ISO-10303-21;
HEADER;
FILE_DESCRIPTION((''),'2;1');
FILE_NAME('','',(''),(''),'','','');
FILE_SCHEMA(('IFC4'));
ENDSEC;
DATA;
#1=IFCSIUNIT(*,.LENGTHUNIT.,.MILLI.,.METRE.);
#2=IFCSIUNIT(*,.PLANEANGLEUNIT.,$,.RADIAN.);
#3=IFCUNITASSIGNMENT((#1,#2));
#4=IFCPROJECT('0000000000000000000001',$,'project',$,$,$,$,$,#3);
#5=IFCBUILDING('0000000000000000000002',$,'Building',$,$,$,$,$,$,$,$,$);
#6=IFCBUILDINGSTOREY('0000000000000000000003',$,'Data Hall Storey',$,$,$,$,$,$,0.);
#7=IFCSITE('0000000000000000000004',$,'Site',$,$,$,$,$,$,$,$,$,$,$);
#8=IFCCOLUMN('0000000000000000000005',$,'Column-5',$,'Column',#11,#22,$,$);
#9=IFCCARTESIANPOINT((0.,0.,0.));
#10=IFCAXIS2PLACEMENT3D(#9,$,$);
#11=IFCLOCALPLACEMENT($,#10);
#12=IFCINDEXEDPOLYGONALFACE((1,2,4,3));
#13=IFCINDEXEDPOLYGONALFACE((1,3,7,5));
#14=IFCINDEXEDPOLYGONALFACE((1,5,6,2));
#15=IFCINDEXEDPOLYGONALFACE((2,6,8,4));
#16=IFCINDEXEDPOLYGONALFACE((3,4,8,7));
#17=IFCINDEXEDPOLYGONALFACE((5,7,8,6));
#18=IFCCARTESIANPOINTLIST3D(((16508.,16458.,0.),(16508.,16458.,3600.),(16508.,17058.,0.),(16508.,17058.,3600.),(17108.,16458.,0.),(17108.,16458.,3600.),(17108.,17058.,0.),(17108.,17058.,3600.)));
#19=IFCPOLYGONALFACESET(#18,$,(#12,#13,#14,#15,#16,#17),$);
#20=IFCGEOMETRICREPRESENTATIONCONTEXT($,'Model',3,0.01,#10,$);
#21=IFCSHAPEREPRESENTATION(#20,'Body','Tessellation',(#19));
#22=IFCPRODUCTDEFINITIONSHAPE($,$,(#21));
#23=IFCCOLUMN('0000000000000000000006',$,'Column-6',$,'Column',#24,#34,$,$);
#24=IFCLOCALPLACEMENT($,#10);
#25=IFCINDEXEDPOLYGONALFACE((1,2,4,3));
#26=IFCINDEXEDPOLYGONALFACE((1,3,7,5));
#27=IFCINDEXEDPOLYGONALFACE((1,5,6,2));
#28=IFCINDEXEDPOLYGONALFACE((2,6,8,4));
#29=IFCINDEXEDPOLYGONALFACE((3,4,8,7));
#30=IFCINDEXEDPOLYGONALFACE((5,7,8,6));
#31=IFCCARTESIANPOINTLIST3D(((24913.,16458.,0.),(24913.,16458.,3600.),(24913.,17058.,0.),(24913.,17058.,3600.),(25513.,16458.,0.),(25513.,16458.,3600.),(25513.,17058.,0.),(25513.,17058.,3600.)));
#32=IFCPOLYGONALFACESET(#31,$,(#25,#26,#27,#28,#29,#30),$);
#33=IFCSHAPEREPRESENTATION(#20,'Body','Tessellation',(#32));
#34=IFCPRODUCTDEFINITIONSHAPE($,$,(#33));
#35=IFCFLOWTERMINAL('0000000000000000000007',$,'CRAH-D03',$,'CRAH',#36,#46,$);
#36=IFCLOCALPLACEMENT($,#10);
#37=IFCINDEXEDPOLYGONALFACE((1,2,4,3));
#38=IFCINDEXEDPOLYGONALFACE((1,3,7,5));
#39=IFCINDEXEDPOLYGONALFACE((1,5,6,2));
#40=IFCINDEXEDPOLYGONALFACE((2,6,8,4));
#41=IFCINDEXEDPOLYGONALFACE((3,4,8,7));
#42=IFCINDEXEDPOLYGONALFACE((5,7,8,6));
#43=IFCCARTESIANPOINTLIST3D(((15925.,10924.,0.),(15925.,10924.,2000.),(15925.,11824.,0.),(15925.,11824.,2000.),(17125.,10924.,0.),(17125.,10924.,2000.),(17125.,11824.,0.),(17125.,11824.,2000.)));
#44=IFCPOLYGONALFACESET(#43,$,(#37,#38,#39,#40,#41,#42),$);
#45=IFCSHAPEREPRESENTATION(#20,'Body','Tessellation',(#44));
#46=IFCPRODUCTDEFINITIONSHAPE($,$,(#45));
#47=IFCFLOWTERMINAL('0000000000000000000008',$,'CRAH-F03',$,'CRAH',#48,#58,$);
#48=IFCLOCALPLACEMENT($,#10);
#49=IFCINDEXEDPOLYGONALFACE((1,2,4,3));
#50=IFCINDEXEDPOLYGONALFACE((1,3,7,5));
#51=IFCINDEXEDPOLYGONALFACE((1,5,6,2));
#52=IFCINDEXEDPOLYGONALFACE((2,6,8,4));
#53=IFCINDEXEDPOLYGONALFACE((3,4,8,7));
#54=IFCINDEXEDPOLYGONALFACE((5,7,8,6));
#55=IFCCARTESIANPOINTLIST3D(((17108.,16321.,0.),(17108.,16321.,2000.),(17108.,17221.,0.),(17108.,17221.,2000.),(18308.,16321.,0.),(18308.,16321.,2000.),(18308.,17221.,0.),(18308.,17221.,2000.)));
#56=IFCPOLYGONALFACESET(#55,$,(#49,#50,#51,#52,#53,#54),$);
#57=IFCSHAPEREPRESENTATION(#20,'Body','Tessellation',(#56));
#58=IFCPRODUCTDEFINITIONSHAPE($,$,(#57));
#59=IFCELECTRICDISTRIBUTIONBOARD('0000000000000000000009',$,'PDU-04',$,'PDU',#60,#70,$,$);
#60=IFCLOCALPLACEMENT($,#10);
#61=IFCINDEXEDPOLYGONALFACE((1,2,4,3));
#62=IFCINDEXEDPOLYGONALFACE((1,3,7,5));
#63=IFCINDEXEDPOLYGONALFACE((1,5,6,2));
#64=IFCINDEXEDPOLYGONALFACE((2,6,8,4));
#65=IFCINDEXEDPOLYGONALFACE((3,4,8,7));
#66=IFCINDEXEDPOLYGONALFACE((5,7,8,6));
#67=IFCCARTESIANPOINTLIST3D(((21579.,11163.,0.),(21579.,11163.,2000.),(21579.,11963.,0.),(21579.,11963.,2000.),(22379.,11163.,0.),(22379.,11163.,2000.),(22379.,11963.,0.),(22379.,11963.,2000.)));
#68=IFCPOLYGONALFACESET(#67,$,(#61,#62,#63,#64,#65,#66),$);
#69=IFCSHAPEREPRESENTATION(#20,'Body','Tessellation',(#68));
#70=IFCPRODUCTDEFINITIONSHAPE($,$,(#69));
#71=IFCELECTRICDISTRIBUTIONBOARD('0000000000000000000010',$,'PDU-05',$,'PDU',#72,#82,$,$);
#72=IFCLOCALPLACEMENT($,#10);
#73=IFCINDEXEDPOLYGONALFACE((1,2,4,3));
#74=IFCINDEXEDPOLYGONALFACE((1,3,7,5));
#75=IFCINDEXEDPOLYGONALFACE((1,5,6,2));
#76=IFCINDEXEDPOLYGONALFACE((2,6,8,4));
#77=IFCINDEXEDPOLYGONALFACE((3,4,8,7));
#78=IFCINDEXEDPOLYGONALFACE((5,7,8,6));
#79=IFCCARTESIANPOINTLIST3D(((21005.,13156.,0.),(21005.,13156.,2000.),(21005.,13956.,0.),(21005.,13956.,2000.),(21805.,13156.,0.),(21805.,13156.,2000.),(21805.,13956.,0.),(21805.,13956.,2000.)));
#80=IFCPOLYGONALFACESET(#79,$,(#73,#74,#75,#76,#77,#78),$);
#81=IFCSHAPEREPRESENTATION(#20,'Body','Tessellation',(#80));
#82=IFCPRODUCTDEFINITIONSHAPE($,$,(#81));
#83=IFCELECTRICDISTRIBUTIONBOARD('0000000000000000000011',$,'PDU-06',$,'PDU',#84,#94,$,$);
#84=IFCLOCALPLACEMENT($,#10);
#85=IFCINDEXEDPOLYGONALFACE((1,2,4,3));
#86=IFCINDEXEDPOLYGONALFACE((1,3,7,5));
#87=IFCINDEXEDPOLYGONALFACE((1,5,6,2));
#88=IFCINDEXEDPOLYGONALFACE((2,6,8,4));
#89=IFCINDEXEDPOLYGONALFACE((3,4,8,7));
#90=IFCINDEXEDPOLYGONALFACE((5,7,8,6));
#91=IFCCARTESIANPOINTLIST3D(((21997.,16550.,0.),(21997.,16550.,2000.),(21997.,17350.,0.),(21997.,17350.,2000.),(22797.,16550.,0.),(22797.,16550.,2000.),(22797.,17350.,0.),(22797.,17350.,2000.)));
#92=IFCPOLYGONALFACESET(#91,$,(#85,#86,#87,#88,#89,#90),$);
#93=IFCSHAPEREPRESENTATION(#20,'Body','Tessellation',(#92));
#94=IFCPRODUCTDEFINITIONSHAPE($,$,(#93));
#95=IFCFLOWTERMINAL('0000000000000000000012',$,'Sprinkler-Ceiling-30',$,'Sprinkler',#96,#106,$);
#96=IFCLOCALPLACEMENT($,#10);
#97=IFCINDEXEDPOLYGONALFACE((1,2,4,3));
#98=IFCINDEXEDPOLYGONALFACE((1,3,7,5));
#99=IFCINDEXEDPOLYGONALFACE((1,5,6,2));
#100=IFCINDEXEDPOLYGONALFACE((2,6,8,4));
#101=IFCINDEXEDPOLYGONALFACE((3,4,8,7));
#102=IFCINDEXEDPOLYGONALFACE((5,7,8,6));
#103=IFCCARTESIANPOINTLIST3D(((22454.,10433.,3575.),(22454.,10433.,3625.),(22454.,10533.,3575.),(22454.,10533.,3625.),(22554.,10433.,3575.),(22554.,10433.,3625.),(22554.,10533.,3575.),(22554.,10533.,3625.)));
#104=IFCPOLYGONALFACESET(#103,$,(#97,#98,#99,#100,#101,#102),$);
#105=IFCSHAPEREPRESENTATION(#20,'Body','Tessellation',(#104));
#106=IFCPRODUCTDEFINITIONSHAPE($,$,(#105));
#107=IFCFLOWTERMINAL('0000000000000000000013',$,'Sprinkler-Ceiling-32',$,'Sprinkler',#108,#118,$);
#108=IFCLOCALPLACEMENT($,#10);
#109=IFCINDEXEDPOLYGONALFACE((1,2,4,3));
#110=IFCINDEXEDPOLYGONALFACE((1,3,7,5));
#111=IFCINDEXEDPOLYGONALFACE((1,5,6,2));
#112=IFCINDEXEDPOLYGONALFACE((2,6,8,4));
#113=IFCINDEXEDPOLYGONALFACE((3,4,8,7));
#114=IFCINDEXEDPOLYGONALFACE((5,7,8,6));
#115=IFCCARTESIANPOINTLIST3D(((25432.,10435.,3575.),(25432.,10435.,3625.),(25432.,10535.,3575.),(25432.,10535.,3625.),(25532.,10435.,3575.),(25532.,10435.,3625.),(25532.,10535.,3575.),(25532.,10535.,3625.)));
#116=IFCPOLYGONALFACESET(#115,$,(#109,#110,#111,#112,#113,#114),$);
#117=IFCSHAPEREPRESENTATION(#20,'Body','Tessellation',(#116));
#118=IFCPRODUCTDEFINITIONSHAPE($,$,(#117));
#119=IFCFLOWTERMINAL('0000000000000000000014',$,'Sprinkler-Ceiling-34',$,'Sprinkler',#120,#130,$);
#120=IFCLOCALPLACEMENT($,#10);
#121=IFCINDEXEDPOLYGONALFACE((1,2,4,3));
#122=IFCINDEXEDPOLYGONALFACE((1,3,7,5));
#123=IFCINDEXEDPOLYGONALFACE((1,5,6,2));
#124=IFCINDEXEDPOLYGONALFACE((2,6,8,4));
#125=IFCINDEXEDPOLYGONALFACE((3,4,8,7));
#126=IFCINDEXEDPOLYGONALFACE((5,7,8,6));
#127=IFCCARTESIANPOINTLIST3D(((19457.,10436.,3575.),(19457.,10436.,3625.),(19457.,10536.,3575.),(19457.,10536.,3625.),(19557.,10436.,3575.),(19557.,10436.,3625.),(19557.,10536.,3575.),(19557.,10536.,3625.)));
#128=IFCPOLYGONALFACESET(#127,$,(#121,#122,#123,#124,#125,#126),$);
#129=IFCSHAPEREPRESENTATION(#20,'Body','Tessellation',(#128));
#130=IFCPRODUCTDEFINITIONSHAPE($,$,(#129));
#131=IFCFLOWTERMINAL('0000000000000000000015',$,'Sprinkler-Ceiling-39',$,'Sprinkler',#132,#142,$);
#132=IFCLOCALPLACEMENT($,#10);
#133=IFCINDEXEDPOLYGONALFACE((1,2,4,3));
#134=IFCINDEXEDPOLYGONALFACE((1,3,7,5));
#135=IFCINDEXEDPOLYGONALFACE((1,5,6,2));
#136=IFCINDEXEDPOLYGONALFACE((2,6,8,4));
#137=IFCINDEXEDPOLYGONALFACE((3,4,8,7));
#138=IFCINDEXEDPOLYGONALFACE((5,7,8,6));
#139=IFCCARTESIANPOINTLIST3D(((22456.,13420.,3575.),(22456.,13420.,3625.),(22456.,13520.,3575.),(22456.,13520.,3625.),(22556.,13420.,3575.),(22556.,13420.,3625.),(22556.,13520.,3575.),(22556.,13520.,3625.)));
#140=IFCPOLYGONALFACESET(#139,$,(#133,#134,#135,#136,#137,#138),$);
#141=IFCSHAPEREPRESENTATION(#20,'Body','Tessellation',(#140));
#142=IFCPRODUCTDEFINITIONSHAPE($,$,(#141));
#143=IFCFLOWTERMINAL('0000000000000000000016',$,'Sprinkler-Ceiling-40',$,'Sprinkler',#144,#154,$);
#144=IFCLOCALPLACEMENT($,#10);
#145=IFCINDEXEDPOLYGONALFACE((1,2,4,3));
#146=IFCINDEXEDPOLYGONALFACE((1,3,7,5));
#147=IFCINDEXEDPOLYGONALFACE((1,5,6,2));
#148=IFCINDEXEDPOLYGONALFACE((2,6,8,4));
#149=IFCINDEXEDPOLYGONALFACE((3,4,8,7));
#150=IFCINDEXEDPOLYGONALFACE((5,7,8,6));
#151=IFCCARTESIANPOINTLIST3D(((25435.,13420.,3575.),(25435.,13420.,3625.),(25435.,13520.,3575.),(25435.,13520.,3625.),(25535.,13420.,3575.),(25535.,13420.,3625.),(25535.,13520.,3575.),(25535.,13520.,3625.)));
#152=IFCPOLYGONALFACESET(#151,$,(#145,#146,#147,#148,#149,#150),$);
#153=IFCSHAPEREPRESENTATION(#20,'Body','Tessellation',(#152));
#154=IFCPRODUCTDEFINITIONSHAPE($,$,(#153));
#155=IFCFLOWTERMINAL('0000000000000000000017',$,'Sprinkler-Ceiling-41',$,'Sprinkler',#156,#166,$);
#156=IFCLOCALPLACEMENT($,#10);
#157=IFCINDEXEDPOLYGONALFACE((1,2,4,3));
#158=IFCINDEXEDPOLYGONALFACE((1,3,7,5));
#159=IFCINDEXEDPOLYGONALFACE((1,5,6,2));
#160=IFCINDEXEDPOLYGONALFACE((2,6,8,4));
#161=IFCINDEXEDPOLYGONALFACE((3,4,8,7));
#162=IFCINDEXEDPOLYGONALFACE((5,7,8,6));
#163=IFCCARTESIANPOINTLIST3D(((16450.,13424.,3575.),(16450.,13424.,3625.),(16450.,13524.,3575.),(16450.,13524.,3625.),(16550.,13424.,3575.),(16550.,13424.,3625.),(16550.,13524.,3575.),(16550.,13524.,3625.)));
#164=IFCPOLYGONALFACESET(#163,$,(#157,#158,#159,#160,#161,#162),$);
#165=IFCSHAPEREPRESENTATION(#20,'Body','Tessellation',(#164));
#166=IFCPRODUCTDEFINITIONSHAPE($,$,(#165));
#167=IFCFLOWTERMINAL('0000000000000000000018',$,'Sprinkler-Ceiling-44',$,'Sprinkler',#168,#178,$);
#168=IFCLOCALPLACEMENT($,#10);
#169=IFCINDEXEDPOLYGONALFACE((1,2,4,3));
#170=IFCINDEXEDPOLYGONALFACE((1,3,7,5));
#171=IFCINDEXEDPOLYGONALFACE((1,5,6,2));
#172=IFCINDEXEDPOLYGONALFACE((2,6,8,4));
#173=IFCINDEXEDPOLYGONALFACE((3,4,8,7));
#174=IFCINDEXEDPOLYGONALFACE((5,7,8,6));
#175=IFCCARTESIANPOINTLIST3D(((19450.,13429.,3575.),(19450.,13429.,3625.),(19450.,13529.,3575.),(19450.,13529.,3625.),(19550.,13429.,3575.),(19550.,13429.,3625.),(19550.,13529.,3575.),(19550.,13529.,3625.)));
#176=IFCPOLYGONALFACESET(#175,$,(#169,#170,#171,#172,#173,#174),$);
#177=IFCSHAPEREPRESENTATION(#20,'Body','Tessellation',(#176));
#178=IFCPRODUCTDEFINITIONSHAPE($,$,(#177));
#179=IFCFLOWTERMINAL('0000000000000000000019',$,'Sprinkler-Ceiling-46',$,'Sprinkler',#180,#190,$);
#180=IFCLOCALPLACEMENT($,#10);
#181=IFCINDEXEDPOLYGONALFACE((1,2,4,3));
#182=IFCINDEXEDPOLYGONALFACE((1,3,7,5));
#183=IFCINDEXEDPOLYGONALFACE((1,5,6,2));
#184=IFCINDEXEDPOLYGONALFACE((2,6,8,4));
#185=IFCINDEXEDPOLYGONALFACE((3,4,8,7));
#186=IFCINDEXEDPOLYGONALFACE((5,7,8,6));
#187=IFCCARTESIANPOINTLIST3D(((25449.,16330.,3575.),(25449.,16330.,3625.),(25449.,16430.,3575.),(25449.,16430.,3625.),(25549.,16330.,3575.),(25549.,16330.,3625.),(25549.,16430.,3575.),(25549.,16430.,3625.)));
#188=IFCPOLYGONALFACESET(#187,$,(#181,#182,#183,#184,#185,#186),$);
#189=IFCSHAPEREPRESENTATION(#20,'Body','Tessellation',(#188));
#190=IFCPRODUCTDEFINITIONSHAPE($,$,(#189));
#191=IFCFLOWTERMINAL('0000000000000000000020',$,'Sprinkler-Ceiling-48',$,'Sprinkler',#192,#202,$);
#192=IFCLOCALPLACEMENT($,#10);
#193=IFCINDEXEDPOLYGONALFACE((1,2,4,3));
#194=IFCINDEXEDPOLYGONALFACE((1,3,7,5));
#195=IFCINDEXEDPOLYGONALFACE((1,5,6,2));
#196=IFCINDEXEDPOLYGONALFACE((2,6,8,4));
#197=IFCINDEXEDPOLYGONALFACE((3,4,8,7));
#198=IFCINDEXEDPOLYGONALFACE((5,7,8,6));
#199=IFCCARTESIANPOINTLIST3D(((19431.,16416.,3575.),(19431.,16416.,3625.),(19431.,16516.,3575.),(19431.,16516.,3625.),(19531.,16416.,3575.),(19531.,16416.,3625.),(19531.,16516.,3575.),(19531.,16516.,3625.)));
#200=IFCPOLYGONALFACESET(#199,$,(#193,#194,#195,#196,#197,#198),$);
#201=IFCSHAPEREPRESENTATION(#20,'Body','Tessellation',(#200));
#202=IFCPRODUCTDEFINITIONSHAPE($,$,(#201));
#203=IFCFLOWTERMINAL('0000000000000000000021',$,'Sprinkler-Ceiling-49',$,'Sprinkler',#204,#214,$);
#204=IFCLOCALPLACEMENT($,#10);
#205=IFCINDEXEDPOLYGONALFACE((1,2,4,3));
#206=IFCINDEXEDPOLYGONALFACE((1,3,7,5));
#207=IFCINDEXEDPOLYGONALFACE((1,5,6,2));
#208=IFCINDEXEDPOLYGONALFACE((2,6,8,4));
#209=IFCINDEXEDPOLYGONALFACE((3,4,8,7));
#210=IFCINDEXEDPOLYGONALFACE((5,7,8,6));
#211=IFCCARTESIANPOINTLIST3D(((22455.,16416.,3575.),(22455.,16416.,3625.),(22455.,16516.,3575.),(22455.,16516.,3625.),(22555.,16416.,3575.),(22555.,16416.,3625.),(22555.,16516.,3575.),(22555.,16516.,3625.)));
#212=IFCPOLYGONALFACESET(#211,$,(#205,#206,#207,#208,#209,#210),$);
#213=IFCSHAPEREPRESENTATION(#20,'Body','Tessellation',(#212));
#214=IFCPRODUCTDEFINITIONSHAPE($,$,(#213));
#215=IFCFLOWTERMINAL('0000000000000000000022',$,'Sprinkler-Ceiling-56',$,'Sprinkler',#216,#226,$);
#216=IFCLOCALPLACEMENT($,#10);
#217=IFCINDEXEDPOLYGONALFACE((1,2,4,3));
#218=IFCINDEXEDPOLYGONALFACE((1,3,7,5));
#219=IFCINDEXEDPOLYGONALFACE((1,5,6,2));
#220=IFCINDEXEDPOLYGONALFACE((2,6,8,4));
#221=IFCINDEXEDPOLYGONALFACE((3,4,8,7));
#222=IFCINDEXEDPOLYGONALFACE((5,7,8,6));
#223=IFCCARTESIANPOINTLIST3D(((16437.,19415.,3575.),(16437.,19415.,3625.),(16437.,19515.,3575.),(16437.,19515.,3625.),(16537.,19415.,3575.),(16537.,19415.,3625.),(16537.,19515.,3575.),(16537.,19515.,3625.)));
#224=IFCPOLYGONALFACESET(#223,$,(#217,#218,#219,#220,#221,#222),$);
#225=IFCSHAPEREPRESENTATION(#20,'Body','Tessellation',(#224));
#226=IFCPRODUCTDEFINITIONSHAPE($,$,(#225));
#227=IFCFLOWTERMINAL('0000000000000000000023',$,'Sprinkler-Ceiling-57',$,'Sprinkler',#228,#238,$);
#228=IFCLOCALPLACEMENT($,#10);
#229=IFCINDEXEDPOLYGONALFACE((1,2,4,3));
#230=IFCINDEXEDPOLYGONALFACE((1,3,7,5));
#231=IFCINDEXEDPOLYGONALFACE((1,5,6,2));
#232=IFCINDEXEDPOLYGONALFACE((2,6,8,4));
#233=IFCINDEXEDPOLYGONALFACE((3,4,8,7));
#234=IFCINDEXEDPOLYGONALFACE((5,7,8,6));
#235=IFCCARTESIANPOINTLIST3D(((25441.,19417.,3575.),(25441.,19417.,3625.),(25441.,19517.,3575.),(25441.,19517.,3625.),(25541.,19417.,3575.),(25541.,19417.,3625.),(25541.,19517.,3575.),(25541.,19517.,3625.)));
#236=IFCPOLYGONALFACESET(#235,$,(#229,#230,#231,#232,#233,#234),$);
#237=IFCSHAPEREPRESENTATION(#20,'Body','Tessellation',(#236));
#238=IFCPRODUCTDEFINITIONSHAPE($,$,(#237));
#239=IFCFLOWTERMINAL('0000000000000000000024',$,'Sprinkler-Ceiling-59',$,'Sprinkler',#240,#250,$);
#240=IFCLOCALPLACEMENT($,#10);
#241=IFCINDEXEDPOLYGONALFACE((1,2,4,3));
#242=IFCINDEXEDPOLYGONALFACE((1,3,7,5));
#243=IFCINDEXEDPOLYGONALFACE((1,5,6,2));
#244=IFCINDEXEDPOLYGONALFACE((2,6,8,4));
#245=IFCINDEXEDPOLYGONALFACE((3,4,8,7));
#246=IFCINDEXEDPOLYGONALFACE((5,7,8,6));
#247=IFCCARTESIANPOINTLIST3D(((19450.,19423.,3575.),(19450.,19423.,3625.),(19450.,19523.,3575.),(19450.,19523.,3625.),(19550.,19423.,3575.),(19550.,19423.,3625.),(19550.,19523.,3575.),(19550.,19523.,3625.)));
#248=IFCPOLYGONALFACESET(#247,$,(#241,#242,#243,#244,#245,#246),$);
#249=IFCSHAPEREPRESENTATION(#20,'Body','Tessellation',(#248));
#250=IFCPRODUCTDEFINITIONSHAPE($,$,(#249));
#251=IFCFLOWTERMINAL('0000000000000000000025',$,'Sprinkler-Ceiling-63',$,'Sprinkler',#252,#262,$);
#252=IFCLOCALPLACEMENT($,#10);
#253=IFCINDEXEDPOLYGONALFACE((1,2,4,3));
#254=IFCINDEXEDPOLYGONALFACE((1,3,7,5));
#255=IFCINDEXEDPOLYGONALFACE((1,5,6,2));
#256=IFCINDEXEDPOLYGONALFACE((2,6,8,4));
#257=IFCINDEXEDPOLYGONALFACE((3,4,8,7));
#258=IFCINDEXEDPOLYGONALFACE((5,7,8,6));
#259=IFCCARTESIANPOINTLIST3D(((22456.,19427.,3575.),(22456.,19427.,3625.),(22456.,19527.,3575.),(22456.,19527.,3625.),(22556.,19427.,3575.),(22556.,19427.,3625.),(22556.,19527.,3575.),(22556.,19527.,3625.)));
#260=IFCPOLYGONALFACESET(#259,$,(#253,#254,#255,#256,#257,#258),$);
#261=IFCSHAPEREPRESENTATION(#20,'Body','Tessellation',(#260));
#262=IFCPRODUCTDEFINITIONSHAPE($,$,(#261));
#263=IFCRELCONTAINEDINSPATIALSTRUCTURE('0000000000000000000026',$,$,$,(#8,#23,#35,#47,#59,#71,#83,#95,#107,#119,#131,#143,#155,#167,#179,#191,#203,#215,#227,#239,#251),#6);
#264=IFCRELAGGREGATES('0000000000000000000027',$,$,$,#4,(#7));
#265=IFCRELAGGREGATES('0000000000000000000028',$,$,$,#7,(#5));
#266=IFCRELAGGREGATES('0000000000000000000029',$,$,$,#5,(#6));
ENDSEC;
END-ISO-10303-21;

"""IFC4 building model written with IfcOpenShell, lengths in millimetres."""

from ifc_helpers import new_model, si_unit, frame, origin, place, context, project, spatial, rectangle, extrude, element, save


model = new_model("IFC4")

# Units and contexts
model_context = context("Model", 3, precision=0.01, world=origin())
ifc_project = project(units=[si_unit("LENGTHUNIT", "METRE", prefix="MILLI"), si_unit("PLANEANGLEUNIT", "RADIAN")])

# Site, building, storey
site = spatial("IfcSite", under=ifc_project, Name="Site")
building = spatial("IfcBuilding", under=site, Name="Building")
storey = spatial("IfcBuildingStorey", under=building, Name="Data Hall Storey", Elevation=0.0)

# Columns
for number, where, name in (
    (1, (16808.0, 16758.0, 0.0), "Column-5"),
    (2, (25213.0, 16758.0, 0.0), "Column-6"),
):
    element("IfcColumn", number, at=place(None, frame(where)), inside=storey, Name=name, ObjectType="Column", context=model_context, shape_type="SweptSolid", body=[
        extrude(rectangle(XDim=600.0, YDim=600.0), origin(), (0.0, 0.0, 1.0), 3600.0),
    ])

# Flow terminals
for number, where, name in (
    (3, (16525.0, 11374.0, 0.0), "CRAH-D03"),
    (4, (17708.0, 16771.0, 0.0), "CRAH-F03"),
):
    element("IfcFlowTerminal", number, at=place(None, frame(where)), inside=storey, Name=name, ObjectType="CRAH", context=model_context, shape_type="SweptSolid", body=[
        extrude(rectangle(XDim=1200.0, YDim=900.0), origin(), (0.0, 0.0, 1.0), 2000.0),
    ])

# Electric distribution boards
for number, where, name in (
    (5, (21979.0, 11563.0, 0.0), "PDU-04"),
    (6, (21405.0, 13556.0, 0.0), "PDU-05"),
    (7, (22397.0, 16950.0, 0.0), "PDU-06"),
):
    element("IfcElectricDistributionBoard", number, at=place(None, frame(where)), inside=storey, Name=name, ObjectType="PDU", context=model_context, shape_type="SweptSolid", body=[
        extrude(rectangle(XDim=800.0, YDim=800.0), origin(), (0.0, 0.0, 1.0), 2000.0),
    ])

# Flow terminals
for number, where, name in (
    (8, (22504.0, 10483.0, 3575.0), "Sprinkler-Ceiling-30"),
    (9, (25482.0, 10485.0, 3575.0), "Sprinkler-Ceiling-32"),
    (10, (19507.0, 10486.0, 3575.0), "Sprinkler-Ceiling-34"),
    (11, (22506.0, 13470.0, 3575.0), "Sprinkler-Ceiling-39"),
    (12, (25485.0, 13470.0, 3575.0), "Sprinkler-Ceiling-40"),
    (13, (16500.0, 13474.0, 3575.0), "Sprinkler-Ceiling-41"),
    (14, (19500.0, 13479.0, 3575.0), "Sprinkler-Ceiling-44"),
    (15, (25499.0, 16380.0, 3575.0), "Sprinkler-Ceiling-46"),
    (16, (19481.0, 16466.0, 3575.0), "Sprinkler-Ceiling-48"),
    (17, (22505.0, 16466.0, 3575.0), "Sprinkler-Ceiling-49"),
    (18, (16487.0, 19465.0, 3575.0), "Sprinkler-Ceiling-56"),
    (19, (25491.0, 19467.0, 3575.0), "Sprinkler-Ceiling-57"),
    (20, (19500.0, 19473.0, 3575.0), "Sprinkler-Ceiling-59"),
    (21, (22506.0, 19477.0, 3575.0), "Sprinkler-Ceiling-63"),
):
    element("IfcFlowTerminal", number, at=place(None, frame(where)), inside=storey, Name=name, ObjectType="Sprinkler", context=model_context, shape_type="SweptSolid", body=[
        extrude(rectangle(XDim=100.0, YDim=100.0), origin(), (0.0, 0.0, 1.0), 50.0),
    ])

save(model, "model.ifc")
